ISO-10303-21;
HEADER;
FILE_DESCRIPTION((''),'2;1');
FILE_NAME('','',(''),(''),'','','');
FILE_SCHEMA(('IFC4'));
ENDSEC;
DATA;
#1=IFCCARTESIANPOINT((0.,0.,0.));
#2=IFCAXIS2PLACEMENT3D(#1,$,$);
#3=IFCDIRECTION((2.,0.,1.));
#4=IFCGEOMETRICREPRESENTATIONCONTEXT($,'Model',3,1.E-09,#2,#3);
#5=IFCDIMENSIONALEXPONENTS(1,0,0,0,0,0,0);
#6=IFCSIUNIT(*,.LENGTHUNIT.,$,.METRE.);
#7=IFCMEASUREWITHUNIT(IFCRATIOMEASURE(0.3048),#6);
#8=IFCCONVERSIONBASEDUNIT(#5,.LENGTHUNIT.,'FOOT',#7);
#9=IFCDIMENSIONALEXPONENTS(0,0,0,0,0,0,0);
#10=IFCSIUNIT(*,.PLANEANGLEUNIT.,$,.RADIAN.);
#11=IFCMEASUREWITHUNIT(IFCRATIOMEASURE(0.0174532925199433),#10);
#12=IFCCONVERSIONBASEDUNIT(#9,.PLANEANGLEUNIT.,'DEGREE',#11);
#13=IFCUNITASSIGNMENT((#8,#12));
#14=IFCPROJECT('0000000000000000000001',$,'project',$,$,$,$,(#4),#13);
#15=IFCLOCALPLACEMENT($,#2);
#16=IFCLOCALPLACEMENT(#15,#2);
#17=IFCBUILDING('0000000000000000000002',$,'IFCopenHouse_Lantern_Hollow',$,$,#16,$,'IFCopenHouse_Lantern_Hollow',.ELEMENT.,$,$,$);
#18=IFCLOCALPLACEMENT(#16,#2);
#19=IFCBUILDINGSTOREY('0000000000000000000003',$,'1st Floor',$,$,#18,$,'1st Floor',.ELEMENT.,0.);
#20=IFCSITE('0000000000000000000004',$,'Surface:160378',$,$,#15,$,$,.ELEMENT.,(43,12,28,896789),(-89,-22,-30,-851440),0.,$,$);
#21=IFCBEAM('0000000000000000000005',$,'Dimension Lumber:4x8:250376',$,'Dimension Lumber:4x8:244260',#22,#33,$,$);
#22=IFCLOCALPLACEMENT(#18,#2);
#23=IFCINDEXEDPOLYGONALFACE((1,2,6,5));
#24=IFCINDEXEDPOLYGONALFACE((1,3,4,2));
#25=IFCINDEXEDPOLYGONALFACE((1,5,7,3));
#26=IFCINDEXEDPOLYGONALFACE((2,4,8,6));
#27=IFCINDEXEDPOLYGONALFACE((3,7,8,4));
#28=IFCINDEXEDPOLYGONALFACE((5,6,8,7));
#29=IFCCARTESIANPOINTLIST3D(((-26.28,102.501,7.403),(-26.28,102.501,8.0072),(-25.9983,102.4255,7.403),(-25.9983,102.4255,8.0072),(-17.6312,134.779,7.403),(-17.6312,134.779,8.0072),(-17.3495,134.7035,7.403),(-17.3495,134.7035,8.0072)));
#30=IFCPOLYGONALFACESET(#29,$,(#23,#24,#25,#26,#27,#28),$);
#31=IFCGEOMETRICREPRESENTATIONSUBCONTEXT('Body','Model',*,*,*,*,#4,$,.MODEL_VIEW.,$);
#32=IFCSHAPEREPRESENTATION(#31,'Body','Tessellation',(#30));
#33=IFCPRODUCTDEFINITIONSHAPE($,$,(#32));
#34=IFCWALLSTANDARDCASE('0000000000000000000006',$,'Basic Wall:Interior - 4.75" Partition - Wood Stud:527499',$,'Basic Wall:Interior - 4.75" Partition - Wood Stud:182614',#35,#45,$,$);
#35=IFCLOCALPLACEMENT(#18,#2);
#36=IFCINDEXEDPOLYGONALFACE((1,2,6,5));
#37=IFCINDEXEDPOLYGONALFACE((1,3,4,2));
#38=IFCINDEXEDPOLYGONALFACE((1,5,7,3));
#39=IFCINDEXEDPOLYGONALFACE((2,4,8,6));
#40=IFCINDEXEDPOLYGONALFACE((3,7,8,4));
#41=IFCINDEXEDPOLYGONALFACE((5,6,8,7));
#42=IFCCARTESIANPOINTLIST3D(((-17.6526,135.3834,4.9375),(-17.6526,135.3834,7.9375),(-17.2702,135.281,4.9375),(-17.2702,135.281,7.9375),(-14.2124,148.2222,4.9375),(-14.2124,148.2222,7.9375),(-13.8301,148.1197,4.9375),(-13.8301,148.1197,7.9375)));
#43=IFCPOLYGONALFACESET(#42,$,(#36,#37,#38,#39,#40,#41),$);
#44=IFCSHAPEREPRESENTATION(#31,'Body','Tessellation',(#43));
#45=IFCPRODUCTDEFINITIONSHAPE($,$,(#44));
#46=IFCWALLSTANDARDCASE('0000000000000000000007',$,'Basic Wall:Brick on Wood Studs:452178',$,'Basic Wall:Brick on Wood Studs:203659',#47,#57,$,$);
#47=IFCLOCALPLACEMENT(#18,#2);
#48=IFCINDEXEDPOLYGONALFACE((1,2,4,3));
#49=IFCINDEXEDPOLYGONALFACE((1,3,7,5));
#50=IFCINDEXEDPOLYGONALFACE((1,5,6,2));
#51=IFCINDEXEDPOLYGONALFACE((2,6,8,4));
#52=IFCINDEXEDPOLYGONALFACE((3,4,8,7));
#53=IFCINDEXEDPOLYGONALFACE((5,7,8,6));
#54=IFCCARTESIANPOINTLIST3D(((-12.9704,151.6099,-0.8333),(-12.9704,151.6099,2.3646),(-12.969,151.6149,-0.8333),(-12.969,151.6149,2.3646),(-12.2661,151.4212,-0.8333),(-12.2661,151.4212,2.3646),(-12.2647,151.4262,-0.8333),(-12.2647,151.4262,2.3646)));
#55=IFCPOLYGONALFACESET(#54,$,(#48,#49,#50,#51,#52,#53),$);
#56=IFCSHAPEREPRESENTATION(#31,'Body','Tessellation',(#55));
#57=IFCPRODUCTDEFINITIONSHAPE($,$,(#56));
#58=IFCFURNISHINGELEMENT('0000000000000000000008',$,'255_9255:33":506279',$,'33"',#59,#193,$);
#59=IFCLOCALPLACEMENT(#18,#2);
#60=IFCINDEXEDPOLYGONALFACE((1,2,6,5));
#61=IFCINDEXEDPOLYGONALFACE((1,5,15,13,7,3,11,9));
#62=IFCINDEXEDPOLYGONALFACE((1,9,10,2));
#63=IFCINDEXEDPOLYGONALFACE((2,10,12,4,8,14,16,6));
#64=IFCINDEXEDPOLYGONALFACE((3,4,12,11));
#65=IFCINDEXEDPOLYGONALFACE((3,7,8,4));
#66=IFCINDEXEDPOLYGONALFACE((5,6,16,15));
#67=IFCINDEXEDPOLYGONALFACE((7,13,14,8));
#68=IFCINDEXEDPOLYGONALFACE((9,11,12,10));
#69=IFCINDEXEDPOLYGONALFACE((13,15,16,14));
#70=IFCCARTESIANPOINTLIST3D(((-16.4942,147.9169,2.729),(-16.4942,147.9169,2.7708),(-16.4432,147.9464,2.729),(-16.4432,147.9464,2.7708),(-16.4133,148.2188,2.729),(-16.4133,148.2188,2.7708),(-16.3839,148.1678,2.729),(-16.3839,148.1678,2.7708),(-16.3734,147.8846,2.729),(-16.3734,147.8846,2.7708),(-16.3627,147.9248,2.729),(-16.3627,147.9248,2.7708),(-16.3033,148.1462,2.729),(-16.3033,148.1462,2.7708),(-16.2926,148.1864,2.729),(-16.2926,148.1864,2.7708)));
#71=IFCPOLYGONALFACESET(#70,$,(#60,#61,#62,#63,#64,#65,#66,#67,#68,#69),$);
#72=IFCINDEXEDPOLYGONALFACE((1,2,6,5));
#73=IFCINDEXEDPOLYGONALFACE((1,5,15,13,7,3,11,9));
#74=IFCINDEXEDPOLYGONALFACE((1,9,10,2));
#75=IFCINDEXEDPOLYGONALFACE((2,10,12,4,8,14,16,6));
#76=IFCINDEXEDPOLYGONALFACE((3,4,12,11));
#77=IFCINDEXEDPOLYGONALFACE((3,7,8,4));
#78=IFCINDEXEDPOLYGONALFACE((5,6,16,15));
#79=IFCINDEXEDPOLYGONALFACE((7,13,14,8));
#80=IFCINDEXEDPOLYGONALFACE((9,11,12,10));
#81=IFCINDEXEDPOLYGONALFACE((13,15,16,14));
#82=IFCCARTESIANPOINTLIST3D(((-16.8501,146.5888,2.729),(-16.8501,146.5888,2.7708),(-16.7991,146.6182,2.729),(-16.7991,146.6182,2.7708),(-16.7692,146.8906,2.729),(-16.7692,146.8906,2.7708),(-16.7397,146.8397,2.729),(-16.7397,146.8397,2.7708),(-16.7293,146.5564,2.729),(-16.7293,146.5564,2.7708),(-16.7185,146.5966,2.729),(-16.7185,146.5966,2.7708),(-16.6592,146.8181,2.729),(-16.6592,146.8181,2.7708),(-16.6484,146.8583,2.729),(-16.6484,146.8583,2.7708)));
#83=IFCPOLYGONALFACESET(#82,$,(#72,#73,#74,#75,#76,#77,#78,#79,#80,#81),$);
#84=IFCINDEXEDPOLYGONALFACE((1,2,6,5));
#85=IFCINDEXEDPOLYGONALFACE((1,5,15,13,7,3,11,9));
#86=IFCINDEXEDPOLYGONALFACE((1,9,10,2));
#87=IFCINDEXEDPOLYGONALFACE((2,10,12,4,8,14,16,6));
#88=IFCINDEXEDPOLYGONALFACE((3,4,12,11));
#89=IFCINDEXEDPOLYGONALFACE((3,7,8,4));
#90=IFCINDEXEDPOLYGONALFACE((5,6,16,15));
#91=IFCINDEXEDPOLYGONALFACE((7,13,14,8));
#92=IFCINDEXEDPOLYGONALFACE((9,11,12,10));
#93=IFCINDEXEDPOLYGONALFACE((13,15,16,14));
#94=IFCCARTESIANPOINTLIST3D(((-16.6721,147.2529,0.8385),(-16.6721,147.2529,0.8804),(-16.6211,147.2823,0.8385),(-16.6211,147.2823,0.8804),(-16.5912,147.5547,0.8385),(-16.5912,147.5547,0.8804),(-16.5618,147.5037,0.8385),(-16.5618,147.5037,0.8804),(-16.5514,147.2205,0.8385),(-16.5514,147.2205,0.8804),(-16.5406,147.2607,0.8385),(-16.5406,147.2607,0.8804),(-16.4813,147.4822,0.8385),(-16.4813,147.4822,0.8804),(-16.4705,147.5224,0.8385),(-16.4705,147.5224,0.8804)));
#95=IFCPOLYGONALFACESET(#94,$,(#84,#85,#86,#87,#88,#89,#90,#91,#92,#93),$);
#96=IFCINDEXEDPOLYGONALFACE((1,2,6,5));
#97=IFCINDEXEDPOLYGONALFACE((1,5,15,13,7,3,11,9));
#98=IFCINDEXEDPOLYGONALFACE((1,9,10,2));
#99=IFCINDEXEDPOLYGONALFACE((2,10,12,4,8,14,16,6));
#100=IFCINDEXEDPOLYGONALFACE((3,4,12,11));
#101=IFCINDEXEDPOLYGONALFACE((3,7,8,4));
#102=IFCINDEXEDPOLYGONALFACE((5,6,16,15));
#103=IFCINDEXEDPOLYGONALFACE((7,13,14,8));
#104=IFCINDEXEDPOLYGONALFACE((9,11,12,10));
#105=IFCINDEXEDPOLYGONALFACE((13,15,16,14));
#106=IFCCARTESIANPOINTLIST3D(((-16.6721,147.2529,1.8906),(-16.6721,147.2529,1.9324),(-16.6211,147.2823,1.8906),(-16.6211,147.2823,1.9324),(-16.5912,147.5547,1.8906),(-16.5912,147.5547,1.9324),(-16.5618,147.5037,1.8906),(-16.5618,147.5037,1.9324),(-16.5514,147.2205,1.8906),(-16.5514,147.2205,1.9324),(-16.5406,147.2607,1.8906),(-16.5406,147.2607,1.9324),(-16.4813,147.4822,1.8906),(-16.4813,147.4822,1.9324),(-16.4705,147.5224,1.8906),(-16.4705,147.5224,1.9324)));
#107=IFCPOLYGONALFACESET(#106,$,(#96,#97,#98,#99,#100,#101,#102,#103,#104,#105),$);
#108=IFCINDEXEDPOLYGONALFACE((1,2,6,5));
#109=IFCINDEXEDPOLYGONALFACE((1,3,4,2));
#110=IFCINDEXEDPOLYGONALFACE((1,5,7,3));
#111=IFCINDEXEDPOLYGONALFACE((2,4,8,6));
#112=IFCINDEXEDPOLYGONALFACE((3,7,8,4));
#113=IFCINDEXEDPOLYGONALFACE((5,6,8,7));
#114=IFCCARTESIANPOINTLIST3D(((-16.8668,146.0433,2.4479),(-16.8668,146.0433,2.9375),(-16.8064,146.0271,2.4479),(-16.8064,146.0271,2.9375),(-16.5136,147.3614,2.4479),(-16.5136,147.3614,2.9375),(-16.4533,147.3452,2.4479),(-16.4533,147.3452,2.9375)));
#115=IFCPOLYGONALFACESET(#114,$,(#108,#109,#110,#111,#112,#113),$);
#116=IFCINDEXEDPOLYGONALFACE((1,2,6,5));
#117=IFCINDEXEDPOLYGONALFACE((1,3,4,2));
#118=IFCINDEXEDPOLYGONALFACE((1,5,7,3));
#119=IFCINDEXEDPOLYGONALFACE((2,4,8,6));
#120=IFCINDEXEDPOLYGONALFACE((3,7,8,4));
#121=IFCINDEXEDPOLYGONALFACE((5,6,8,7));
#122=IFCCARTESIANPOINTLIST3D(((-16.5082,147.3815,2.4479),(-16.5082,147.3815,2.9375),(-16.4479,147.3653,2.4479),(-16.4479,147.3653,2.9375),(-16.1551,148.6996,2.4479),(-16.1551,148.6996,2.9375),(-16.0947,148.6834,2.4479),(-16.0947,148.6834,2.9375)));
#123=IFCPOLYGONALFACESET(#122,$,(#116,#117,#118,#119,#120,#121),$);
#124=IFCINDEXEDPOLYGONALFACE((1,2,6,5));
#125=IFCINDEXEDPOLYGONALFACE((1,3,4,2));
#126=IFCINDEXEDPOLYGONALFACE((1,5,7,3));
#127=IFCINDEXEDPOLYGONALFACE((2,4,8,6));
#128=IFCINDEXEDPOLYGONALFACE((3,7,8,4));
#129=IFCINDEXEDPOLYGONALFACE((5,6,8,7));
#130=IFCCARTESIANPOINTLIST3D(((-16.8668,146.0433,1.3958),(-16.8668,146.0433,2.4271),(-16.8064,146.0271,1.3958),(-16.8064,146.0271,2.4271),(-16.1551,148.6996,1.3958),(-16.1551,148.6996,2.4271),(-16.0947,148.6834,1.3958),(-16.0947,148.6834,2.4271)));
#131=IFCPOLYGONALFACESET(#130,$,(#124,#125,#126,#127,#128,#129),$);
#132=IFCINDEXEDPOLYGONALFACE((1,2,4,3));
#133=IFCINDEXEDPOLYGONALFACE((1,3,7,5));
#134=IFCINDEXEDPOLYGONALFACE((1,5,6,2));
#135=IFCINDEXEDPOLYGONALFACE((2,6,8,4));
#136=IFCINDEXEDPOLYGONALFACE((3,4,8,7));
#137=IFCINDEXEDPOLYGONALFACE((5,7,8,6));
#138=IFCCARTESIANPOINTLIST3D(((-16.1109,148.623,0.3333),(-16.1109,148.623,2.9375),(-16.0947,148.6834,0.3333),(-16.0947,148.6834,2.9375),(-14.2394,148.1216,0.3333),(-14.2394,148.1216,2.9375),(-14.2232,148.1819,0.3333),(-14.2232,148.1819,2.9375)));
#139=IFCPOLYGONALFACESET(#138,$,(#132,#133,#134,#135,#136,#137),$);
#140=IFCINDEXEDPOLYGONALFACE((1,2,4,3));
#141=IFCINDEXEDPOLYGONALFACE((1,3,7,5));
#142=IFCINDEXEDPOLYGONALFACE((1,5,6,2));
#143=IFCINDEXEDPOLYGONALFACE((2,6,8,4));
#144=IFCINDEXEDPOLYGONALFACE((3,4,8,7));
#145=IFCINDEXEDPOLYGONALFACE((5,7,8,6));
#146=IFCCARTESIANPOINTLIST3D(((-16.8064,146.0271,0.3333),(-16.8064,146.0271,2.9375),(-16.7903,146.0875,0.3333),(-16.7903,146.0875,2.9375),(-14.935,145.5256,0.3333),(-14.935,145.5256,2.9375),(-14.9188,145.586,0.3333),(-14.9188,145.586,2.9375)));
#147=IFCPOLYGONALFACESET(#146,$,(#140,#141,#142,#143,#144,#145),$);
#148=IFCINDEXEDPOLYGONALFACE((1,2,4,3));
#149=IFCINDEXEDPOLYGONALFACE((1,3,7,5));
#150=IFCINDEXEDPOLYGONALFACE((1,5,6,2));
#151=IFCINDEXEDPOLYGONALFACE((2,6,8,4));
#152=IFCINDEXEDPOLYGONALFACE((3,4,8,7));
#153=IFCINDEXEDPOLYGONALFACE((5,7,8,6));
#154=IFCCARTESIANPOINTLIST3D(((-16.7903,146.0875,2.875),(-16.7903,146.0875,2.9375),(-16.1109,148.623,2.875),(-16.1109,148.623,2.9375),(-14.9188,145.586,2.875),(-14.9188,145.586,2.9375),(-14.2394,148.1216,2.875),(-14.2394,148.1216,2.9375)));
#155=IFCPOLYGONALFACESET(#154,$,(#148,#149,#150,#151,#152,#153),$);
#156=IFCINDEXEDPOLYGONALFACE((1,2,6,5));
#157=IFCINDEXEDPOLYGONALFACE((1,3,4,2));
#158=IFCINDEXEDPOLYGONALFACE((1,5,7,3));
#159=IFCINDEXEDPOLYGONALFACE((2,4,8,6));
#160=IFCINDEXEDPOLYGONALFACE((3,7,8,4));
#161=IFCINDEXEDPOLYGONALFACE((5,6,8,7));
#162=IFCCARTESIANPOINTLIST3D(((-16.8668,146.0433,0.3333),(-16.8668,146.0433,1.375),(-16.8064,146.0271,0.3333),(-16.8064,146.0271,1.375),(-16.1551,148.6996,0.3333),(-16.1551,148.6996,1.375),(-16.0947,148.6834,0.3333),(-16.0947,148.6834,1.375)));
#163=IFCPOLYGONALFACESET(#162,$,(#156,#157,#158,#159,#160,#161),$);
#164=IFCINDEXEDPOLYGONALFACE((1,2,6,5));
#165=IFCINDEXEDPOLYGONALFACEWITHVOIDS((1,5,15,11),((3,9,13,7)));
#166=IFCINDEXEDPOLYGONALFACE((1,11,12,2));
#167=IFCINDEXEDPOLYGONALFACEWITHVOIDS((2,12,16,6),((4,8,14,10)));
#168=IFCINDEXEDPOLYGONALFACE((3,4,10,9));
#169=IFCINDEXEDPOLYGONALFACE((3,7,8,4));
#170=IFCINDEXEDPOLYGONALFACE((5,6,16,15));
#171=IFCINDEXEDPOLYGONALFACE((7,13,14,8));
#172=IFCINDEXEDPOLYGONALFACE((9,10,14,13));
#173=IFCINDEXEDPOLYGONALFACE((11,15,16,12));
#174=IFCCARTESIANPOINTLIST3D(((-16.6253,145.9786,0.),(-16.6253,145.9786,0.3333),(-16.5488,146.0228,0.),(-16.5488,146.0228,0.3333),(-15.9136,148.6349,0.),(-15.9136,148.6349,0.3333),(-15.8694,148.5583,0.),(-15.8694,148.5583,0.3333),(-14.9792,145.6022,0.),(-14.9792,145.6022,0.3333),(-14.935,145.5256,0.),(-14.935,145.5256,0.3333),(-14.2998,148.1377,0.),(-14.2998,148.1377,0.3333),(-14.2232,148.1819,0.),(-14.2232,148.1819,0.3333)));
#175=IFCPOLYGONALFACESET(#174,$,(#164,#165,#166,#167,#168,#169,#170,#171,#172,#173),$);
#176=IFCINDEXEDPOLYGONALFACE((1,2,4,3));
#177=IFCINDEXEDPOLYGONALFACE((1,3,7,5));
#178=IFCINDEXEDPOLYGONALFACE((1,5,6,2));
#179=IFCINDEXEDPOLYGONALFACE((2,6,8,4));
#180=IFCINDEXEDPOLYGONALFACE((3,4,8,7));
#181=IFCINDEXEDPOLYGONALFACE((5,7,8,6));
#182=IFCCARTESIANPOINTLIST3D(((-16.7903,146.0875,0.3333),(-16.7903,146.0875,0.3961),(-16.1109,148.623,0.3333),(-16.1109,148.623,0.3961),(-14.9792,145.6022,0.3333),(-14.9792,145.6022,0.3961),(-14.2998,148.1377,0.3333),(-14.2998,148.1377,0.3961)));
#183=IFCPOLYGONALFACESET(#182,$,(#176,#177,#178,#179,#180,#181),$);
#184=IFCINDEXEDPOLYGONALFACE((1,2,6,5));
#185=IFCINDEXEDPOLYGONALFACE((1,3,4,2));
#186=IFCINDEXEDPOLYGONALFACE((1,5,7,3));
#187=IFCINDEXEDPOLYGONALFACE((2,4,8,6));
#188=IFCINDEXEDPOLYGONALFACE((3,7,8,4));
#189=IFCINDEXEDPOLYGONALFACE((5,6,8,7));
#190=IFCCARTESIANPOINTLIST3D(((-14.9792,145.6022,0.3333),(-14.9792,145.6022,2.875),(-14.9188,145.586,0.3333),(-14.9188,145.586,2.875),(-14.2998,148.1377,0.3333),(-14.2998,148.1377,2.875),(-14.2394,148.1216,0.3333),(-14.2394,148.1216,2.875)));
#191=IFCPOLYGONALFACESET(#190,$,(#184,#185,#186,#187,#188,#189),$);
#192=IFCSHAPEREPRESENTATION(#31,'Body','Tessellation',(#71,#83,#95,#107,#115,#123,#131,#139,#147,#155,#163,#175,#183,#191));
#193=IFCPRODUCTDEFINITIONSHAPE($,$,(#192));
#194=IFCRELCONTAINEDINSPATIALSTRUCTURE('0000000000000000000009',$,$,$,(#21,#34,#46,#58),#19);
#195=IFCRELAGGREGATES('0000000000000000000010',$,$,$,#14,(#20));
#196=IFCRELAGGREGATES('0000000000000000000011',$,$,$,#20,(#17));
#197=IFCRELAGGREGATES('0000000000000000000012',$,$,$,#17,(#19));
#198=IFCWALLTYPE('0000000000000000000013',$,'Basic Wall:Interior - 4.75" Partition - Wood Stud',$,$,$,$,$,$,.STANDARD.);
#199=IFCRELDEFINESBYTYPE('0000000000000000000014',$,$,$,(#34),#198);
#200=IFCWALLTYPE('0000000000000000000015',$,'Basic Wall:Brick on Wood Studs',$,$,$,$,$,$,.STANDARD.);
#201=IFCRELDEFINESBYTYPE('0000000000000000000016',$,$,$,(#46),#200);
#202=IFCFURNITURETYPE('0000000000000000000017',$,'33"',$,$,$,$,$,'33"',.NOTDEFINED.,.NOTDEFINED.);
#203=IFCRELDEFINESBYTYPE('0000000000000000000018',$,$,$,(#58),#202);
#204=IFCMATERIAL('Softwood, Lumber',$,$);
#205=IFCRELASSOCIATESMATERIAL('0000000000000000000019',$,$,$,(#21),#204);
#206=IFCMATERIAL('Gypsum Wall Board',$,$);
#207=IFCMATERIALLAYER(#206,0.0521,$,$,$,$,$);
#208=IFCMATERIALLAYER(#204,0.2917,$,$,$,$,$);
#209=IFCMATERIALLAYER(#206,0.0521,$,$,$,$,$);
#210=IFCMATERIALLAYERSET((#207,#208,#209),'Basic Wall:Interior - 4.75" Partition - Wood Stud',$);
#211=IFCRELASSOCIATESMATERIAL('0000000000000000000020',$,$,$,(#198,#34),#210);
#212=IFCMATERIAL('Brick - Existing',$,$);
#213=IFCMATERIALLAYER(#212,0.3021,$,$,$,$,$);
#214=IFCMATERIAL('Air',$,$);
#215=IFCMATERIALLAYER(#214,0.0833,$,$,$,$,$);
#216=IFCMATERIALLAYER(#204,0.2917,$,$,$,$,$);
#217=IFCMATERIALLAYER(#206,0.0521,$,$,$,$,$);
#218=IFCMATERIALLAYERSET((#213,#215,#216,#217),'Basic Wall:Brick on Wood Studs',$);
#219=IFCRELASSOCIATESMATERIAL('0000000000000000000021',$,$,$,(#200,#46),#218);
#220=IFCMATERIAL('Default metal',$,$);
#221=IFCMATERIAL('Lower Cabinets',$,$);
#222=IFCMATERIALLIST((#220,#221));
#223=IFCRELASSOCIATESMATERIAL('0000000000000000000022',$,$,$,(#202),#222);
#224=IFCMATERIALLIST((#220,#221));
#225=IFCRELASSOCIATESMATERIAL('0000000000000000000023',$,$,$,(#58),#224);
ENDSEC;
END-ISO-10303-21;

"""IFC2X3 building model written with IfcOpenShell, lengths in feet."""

from ifc_helpers import new_model, entity, si_unit, converted_unit, direction, frame, frame_2d, origin, origin_2d_with_axis, place, context, subcontext, project, spatial, polyline, rectangle, outline, extrude, source, transform, mapped, material, material_list, layer, layer_set, layer_usage, type_object, type_shapes, element, save


model = new_model("IFC2X3")

# Units and contexts
model_context = context("Model", 3, precision=1e-09, world=origin(), true_north=direction((2.0, 0.0, 1.0)))
body_context = subcontext(model_context, "Body", "Model", "MODEL_VIEW")
ifc_project = project(units=[converted_unit("LENGTHUNIT", "FOOT", entity("IfcRatioMeasure", 0.3048), si_unit("LENGTHUNIT", "METRE"), dimensions=[1, 0, 0, 0, 0, 0, 0]), converted_unit("PLANEANGLEUNIT", "DEGREE", entity("IfcRatioMeasure", 0.0174532925199433), si_unit("PLANEANGLEUNIT", "RADIAN"), dimensions=[0, 0, 0, 0, 0, 0, 0])], contexts=[model_context])

# Site, building, storey
site_placement = place(None, origin())
site = spatial("IfcSite", under=ifc_project, at=site_placement, Name="Surface:160378", CompositionType="ELEMENT", RefLatitude=(43, 12, 28, 896789), RefLongitude=(-89, -22, -30, -851440), RefElevation=0.0)
building_placement = place(site_placement, origin())
building = spatial("IfcBuilding", under=site, at=building_placement, Name="IFCopenHouse_Lantern_Hollow", LongName="IFCopenHouse_Lantern_Hollow", CompositionType="ELEMENT")
storey_placement = place(building_placement, origin())
storey = spatial("IfcBuildingStorey", under=building, at=storey_placement, Name="1st Floor", LongName="1st Floor", CompositionType="ELEMENT", Elevation=0.0)

# Beam
ifc_material_1 = material(Name="Softwood, Lumber")
beam_1_placement = place(storey_placement, frame((-17.4903, 134.7413, 7.403), z_axis=(0.0, 0.0, 1.0), x_axis=(-0.258819, -0.965926, 0.0)))
element("IfcBeam", 1, at=beam_1_placement, inside=storey, material=ifc_material_1, Name="Dimension Lumber:4x8:250376", ObjectType="Dimension Lumber:4x8:244260", context=body_context, shape_type="SweptSolid", body=[
    extrude(rectangle(XDim=0.6042, YDim=0.2917, at=frame_2d((0.0, 0.0), x_axis=(1.0, 0.0))), frame((0.0, 0.0, 0.3021), z_axis=(1.0, 0.0, 0.0), x_axis=(0.0, 0.0, -1.0)), (0.0, 0.0, 1.0), 33.4167),
])

# Walls
ifc_material_2 = material(Name="Gypsum Wall Board")
ifc_layer_1 = layer(ifc_material_2, 0.0521)
ifc_layer_2 = layer(ifc_material_1, 0.2917)
ifc_layer_3 = layer(ifc_material_2, 0.0521)
ifc_layer_set_1 = layer_set([ifc_layer_1, ifc_layer_2, ifc_layer_3], Name="Basic Wall:Interior - 4.75\" Partition - Wood Stud")
ifc_layer_usage_1 = layer_usage(ifc_layer_set_1, "AXIS2", "POSITIVE", -0.1979)
wall_type_1 = type_object("IfcWallType", Name="Basic Wall:Interior - 4.75\" Partition - Wood Stud", PredefinedType="STANDARD", material=ifc_layer_set_1)
wall_1_placement = place(storey_placement, frame((-14.0212, 148.171, 4.9375), z_axis=(0.0, 0.0, 1.0), x_axis=(-0.258819, -0.965926, 0.0)))
element("IfcWallStandardCase", 2, at=wall_1_placement, inside=storey, type_object=wall_type_1, material=ifc_layer_usage_1, Name="Basic Wall:Interior - 4.75\" Partition - Wood Stud:527499", ObjectType="Basic Wall:Interior - 4.75\" Partition - Wood Stud:182614", context=body_context, shape_type="SweptSolid", body=[
    extrude(rectangle(XDim=13.2917, YDim=0.3958, at=frame_2d((6.6458, 0.0), x_axis=(-1.0, 0.0))), origin(), (0.0, 0.0, 1.0), 3.0),
])
ifc_material_3 = material(Name="Brick - Existing")
ifc_layer_4 = layer(ifc_material_3, 0.3021)
ifc_material_4 = material(Name="Air")
ifc_layer_5 = layer(ifc_material_4, 0.0833)
ifc_layer_6 = layer(ifc_material_1, 0.2917)
ifc_layer_7 = layer(ifc_material_2, 0.0521)
ifc_layer_set_2 = layer_set([ifc_layer_4, ifc_layer_5, ifc_layer_6, ifc_layer_7], Name="Basic Wall:Brick on Wood Studs")
ifc_layer_usage_2 = layer_usage(ifc_layer_set_2, "AXIS2", "NEGATIVE", 0.3646)
wall_type_2 = type_object("IfcWallType", Name="Basic Wall:Brick on Wood Studs", PredefinedType="STANDARD", material=ifc_layer_set_2)
wall_2_placement = place(storey_placement, frame((-12.6169, 151.5206, -0.8333), z_axis=(0.0, 0.0, 1.0), x_axis=(-0.258819, -0.965926, 0.0)))
element("IfcWallStandardCase", 3, at=wall_2_placement, inside=storey, type_object=wall_type_2, material=ifc_layer_usage_2, Name="Basic Wall:Brick on Wood Studs:452178", ObjectType="Basic Wall:Brick on Wood Studs:203659", context=body_context, shape_type="SweptSolid", body=[
    extrude(rectangle(XDim=0.0052, YDim=0.7292, at=frame_2d((0.0026, 0.0), x_axis=(-1.0, 0.0))), origin(), (0.0, 0.0, 1.0), 3.1979),
])

# Furnishing element
ifc_material_5 = material(Name="Default metal")
ifc_material_6 = material(Name="Lower Cabinets")
ifc_material_list_1 = material_list([ifc_material_5, ifc_material_6])
ifc_material_list_2 = material_list([ifc_material_5, ifc_material_6])
furniture_type_1 = type_object("IfcFurnitureType", Name="33\"", ElementType="33\"", AssemblyPlace="NOTDEFINED", material=ifc_material_list_2)
shared_shape_1 = source(origin(), body_context, "Body", "SweptSolid", [
    extrude(outline(polyline([(-0.0521, -0.1562), (0.0729, -0.1562), (0.0729, 0.1562), (-0.0521, 0.1562), (-0.0521, 0.1146), (0.0313, 0.1146), (0.0313, -0.1146), (-0.0521, -0.1146), (-0.0521, -0.1562)])), frame((-0.626, -2.0521, 2.729), z_axis=(0.0, 0.0, 1.0), x_axis=(0.0, -1.0, 0.0)), (0.0, 0.0, 1.0), 0.0418),
    extrude(outline(polyline([(-0.0521, -0.1562), (0.0729, -0.1562), (0.0729, 0.1562), (-0.0521, 0.1562), (-0.0521, 0.1146), (0.0313, 0.1146), (0.0313, -0.1146), (-0.0521, -0.1146), (-0.0521, -0.1562)])), frame((0.749, -2.0521, 2.729), z_axis=(0.0, 0.0, 1.0), x_axis=(0.0, -1.0, 0.0)), (0.0, 0.0, 1.0), 0.0418),
    extrude(outline(polyline([(-0.0521, -0.1562), (0.0729, -0.1562), (0.0729, 0.1562), (-0.0521, 0.1562), (-0.0521, 0.1146), (0.0313, 0.1146), (0.0313, -0.1146), (-0.0521, -0.1146), (-0.0521, -0.1562)])), frame((0.0615, -2.0521, 0.8385), z_axis=(0.0, 0.0, 1.0), x_axis=(0.0, -1.0, 0.0)), (0.0, 0.0, 1.0), 0.0418),
    extrude(outline(polyline([(-0.0521, -0.1562), (0.0729, -0.1562), (0.0729, 0.1562), (-0.0521, 0.1562), (-0.0521, 0.1146), (0.0313, 0.1146), (0.0313, -0.1146), (-0.0521, -0.1146), (-0.0521, -0.1562)])), frame((0.0615, -2.0521, 1.8906), z_axis=(0.0, 0.0, 1.0), x_axis=(0.0, -1.0, 0.0)), (0.0, 0.0, 1.0), 0.0418),
    extrude(rectangle(XDim=0.0625, YDim=1.3646, at=frame_2d((0.0, 0.0), x_axis=(1.0, 0.0))), frame((0.7542, -1.9688, 2.4479), z_axis=(0.0, 0.0, 1.0), x_axis=(0.0, 1.0, 0.0)), (0.0, 0.0, 1.0), 0.4896),
    extrude(rectangle(XDim=0.0625, YDim=1.3646, at=origin_2d_with_axis()), frame((-0.6312, -1.9688, 2.4479), z_axis=(0.0, 0.0, 1.0), x_axis=(0.0, 1.0, 0.0)), (0.0, 0.0, 1.0), 0.4896),
    extrude(rectangle(XDim=0.0625, YDim=2.75, at=frame_2d((0.0, 0.0), x_axis=(1.0, 0.0))), frame((0.0615, -1.9688, 1.3958), z_axis=(0.0, 0.0, 1.0), x_axis=(0.0, 1.0, 0.0)), (0.0, 0.0, 1.0), 1.0313),
    extrude(rectangle(XDim=0.0625, YDim=1.9375, at=frame_2d((0.0, 0.0), x_axis=(1.0, 0.0))), frame((-1.2823, -0.9687, 0.3333)), (0.0, 0.0, 1.0), 2.6042),
    extrude(rectangle(XDim=0.0625, YDim=1.9375, at=frame_2d((0.0, 0.0), x_axis=(1.0, 0.0))), frame((1.4052, -0.9687, 0.3333)), (0.0, 0.0, 1.0), 2.6042),
    extrude(rectangle(XDim=2.625, YDim=1.9375, at=origin_2d_with_axis()), frame((0.0615, -0.9688, 2.875), z_axis=(0.0, 0.0, 1.0), x_axis=(-1.0, 0.0, 0.0)), (0.0, 0.0, 1.0), 0.0625),
    extrude(rectangle(XDim=0.0625, YDim=2.75, at=frame_2d((0.0, 0.0), x_axis=(1.0, 0.0))), frame((0.0615, -1.9688, 0.3333), z_axis=(0.0, 0.0, 1.0), x_axis=(0.0, 1.0, 0.0)), (0.0, 0.0, 1.0), 1.0417),
    extrude(outline(polyline([(-1.375, -0.875), (1.375, -0.875), (1.375, 0.875), (-1.375, 0.875), (-1.375, -0.875)]), holes=[polyline([(-1.3125, -0.8125), (-1.3125, 0.8125), (1.3125, 0.8125), (1.3125, -0.8125), (-1.3125, -0.8125)])]), frame((0.0615, -0.875, 0.0)), (0.0, 0.0, 1.0), 0.3333),
    extrude(rectangle(XDim=2.625, YDim=1.875, at=frame_2d((0.0, 0.0), x_axis=(1.0, 0.0))), frame((0.0615, -1.0, 0.3333), z_axis=(0.0, 0.0, 1.0), x_axis=(-1.0, 0.0, 0.0)), (0.0, 0.0, 1.0), 0.0627),
    extrude(rectangle(XDim=0.0625, YDim=2.625, at=origin_2d_with_axis()), frame((0.0615, -0.0312, 0.3333), z_axis=(0.0, 0.0, 1.0), x_axis=(0.0, 1.0, 0.0)), (0.0, 0.0, 1.0), 2.5417),
])
type_shapes(furniture_type_1, [shared_shape_1])
furnishing_1_placement = place(storey_placement, frame((-14.5632, 146.9132, 0.0), z_axis=(0.0, 0.0, 1.0), x_axis=(-0.258819, -0.965926, 0.0)))
element("IfcFurnishingElement", 4, at=furnishing_1_placement, inside=storey, type_object=furniture_type_1, material=ifc_material_list_1, Name="255_9255:33\":506279", ObjectType="33\"", context=body_context, shape_type="MappedRepresentation", body=[
    mapped(shared_shape_1, transform((0.0, 0.0, 0.0), scale=1.0)),
])

save(model, "model.ifc")
